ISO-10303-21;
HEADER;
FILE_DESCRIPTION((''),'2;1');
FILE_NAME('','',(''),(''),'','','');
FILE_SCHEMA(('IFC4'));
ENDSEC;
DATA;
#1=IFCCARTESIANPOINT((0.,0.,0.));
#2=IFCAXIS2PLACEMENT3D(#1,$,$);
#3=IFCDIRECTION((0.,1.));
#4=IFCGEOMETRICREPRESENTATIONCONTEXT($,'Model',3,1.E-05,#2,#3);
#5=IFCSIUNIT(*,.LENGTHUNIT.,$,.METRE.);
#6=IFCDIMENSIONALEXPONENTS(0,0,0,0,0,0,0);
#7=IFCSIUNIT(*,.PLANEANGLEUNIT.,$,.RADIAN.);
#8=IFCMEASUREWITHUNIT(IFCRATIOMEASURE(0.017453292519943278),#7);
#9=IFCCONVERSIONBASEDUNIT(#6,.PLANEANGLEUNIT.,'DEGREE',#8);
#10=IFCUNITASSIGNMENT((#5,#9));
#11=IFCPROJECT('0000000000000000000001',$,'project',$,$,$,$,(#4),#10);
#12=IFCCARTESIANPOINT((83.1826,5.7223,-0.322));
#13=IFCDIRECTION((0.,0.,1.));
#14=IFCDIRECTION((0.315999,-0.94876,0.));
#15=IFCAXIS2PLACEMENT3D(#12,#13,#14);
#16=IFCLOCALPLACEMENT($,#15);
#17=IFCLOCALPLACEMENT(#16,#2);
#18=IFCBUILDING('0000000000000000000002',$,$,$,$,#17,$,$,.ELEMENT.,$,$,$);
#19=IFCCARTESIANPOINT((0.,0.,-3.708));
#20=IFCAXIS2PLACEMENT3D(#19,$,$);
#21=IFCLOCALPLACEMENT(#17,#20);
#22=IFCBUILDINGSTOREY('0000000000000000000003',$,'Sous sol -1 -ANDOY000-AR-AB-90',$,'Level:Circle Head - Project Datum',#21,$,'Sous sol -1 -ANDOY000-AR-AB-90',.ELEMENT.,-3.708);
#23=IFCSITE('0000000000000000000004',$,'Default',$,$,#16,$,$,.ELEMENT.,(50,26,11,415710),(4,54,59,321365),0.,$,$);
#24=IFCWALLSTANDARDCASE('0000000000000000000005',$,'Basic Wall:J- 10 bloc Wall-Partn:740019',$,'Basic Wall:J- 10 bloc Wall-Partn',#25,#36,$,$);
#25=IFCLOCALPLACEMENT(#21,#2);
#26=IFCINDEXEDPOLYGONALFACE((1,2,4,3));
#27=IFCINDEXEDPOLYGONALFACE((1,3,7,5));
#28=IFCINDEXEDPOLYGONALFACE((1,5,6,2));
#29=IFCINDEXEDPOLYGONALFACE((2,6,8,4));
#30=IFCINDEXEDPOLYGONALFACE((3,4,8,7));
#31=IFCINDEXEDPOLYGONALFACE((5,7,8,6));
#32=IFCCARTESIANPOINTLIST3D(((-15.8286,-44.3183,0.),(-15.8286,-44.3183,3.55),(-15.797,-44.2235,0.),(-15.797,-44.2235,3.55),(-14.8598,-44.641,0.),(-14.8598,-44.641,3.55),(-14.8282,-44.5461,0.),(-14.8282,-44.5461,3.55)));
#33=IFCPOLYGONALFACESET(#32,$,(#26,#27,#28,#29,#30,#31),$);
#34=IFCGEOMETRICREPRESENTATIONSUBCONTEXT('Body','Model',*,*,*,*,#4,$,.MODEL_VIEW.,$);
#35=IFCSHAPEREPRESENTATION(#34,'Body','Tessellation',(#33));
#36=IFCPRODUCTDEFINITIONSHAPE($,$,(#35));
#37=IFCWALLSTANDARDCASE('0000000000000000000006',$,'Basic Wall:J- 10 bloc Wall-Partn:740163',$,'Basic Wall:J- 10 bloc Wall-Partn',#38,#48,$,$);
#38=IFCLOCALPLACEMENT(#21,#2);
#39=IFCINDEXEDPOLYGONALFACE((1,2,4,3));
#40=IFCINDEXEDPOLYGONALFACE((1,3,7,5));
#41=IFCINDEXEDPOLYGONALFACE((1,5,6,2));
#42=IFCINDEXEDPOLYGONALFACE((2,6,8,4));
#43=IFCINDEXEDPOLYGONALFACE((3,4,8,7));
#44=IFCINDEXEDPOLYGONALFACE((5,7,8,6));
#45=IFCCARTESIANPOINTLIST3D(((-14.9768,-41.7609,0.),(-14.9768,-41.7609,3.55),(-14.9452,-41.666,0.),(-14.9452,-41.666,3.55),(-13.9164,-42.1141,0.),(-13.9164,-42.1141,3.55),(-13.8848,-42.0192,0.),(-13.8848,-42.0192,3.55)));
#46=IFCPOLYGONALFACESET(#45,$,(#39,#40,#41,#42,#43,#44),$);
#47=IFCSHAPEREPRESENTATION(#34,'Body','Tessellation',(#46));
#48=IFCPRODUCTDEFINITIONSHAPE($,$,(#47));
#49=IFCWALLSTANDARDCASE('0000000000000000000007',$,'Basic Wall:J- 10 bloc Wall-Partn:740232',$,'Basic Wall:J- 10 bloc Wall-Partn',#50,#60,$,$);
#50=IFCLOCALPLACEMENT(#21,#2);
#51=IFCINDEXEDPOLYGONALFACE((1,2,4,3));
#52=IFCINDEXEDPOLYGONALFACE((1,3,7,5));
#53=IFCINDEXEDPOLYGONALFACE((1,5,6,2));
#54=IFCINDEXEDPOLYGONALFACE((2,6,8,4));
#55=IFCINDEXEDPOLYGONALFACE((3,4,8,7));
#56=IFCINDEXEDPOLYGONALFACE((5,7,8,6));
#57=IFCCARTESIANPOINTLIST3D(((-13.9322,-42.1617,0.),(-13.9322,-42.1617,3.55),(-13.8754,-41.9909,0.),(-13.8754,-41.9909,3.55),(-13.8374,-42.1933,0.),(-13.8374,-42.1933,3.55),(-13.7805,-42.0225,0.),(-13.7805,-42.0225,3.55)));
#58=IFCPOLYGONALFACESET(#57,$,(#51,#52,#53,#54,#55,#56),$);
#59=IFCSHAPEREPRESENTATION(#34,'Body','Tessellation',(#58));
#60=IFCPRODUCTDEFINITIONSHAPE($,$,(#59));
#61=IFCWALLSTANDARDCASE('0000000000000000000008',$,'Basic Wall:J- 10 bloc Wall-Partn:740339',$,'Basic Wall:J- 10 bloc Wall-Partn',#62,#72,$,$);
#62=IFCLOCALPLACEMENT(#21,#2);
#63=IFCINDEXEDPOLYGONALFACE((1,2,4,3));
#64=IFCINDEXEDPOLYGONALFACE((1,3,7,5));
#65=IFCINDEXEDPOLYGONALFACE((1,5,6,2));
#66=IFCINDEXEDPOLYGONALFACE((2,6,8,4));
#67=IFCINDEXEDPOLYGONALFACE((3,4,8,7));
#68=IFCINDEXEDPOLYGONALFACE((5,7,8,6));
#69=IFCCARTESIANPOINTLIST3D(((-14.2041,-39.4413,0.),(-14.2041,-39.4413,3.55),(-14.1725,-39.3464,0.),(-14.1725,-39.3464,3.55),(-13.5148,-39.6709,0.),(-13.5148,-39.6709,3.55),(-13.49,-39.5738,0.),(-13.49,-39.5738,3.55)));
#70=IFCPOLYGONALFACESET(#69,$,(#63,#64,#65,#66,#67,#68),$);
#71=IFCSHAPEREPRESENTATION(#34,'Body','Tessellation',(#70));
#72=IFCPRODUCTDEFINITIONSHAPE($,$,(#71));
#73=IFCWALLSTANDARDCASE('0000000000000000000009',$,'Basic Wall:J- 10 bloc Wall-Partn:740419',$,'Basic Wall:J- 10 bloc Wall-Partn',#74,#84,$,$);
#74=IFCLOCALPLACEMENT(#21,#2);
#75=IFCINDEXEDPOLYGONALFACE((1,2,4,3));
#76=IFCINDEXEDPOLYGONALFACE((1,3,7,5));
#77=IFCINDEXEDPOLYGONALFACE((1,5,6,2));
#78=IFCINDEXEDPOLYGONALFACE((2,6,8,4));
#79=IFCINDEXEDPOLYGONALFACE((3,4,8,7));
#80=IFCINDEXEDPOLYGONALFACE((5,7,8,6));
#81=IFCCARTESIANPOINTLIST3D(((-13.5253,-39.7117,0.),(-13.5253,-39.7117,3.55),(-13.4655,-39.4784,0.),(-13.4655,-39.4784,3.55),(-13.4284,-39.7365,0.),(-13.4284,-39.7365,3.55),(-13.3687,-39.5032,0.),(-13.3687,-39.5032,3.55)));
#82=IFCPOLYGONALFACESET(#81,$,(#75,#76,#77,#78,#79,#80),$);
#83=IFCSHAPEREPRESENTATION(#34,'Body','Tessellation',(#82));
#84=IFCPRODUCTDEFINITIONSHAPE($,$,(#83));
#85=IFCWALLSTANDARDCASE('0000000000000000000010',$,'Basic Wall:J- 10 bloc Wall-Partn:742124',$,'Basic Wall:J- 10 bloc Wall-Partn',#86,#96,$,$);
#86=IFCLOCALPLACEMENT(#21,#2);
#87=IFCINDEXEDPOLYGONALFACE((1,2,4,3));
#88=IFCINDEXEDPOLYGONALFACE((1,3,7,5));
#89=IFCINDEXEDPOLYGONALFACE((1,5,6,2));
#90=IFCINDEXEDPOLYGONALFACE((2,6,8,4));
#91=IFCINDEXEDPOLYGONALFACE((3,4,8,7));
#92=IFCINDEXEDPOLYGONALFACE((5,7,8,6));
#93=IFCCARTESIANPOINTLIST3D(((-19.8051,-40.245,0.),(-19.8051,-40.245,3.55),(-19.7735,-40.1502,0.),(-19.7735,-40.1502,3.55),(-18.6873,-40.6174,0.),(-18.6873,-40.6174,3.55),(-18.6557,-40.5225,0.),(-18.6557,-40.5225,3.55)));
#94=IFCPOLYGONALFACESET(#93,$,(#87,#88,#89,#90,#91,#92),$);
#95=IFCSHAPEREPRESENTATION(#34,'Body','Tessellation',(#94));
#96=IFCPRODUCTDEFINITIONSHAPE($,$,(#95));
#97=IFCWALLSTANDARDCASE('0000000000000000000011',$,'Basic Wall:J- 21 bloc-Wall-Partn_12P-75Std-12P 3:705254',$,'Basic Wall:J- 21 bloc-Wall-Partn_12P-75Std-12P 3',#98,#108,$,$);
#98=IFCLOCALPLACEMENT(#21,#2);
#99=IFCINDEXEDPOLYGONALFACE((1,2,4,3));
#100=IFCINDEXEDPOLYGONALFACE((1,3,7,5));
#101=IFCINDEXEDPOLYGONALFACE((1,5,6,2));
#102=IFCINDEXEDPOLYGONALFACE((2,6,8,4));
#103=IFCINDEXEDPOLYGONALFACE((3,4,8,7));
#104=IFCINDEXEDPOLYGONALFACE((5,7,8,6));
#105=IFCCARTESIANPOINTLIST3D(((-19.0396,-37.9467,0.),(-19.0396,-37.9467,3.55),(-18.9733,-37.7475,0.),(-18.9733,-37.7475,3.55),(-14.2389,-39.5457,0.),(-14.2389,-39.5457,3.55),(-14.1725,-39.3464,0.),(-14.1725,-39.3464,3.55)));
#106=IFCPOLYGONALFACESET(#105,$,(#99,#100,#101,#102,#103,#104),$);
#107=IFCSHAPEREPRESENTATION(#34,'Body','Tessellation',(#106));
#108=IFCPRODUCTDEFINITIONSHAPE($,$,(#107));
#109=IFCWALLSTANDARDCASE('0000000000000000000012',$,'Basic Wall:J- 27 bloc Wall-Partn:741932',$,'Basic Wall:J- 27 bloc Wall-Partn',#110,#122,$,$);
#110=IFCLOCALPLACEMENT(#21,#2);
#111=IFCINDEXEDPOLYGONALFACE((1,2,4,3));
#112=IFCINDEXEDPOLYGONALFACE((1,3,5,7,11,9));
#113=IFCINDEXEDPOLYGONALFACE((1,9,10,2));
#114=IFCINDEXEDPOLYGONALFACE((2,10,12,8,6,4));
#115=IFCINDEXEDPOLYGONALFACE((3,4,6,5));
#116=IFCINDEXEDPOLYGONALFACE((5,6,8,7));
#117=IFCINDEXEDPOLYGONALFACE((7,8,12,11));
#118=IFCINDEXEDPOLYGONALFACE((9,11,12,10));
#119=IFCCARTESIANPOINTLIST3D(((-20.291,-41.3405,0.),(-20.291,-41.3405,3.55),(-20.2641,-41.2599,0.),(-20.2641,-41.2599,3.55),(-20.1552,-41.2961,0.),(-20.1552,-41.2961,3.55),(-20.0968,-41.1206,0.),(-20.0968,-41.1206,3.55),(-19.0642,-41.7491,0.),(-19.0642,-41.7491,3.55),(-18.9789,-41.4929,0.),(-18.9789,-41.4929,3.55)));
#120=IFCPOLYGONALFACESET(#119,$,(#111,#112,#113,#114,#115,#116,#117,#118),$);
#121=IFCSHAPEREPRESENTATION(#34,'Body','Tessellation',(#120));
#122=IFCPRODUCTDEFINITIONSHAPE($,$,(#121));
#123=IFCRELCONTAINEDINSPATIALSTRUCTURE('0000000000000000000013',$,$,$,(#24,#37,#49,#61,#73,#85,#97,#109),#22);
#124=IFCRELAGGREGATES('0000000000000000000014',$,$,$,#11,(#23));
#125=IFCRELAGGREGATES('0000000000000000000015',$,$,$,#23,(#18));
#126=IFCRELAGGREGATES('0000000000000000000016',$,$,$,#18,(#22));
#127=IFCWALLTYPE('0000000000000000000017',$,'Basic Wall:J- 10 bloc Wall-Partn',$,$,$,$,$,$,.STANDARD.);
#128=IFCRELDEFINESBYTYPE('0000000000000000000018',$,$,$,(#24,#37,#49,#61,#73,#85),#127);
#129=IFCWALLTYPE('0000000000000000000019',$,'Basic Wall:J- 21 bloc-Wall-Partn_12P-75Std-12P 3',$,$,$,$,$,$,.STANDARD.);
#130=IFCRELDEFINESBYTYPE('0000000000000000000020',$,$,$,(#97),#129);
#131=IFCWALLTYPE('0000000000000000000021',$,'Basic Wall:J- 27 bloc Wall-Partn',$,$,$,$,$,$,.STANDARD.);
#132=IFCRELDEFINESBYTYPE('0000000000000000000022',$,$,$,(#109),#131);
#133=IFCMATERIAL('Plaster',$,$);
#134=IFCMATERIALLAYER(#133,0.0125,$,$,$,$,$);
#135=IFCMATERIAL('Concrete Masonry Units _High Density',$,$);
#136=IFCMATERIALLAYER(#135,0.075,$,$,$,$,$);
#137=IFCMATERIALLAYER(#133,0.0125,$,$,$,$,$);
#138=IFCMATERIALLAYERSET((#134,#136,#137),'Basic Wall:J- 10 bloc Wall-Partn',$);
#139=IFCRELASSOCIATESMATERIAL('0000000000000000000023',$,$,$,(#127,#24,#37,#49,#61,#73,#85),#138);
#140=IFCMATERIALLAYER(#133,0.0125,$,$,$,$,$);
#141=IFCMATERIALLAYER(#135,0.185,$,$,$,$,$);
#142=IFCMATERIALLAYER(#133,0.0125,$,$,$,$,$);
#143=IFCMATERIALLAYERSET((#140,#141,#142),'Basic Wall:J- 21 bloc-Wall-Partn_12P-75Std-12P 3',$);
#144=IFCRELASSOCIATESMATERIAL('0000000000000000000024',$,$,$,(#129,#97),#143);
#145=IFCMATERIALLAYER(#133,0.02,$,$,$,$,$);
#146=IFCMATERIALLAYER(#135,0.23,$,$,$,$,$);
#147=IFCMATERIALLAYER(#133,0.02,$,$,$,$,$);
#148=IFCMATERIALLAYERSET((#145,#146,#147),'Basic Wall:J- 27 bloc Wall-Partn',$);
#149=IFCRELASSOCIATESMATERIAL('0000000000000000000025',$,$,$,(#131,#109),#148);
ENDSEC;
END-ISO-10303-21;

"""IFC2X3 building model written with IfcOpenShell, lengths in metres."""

from ifc_helpers import new_model, entity, si_unit, converted_unit, direction, frame, frame_2d, origin, place, context, subcontext, project, spatial, polyline, rectangle, outline, extrude, clip, bounded_halfspace, material, layer, layer_set, layer_usage, type_object, element, save


model = new_model("IFC2X3")

# Units and contexts
model_context = context("Model", 3, precision=1e-05, world=origin(), true_north=direction((0.0, 1.0)))
body_context = subcontext(model_context, "Body", "Model", "MODEL_VIEW")
ifc_project = project(units=[si_unit("LENGTHUNIT", "METRE"), converted_unit("PLANEANGLEUNIT", "DEGREE", entity("IfcRatioMeasure", 0.017453292519943278), si_unit("PLANEANGLEUNIT", "RADIAN"), dimensions=[0, 0, 0, 0, 0, 0, 0])], contexts=[model_context])

# Site, building, storey
site_placement = place(None, frame((83.1826, 5.7223, -0.322), z_axis=(0.0, 0.0, 1.0), x_axis=(0.315999, -0.94876, 0.0)))
site = spatial("IfcSite", under=ifc_project, at=site_placement, Name="Default", CompositionType="ELEMENT", RefLatitude=(50, 26, 11, 415710), RefLongitude=(4, 54, 59, 321365), RefElevation=0.0)
building_placement = place(site_placement, origin())
building = spatial("IfcBuilding", under=site, at=building_placement, CompositionType="ELEMENT")
storey_placement = place(building_placement, frame((0.0, 0.0, -3.708)))
storey = spatial("IfcBuildingStorey", under=building, at=storey_placement, Name="Sous sol -1 -ANDOY000-AR-AB-90", ObjectType="Level:Circle Head - Project Datum", LongName="Sous sol -1 -ANDOY000-AR-AB-90", CompositionType="ELEMENT", Elevation=-3.708)

# Shared definitions
ifc_material_1 = material(Name="Plaster")

# Shared definitions
ifc_layer_1 = layer(ifc_material_1, 0.0125)
ifc_material_2 = material(Name="Concrete Masonry Units _High Density")
ifc_layer_2 = layer(ifc_material_2, 0.075)
ifc_layer_3 = layer(ifc_material_1, 0.0125)
ifc_layer_set_1 = layer_set([ifc_layer_1, ifc_layer_2, ifc_layer_3], Name="Basic Wall:J- 10 bloc Wall-Partn")
ifc_layer_usage_1 = layer_usage(ifc_layer_set_1, "AXIS2", "NEGATIVE", 0.05)
wall_type_1 = type_object("IfcWallType", Name="Basic Wall:J- 10 bloc Wall-Partn", PredefinedType="STANDARD", material=ifc_layer_set_1)

# Walls
wall_1_placement = place(storey_placement, frame((-14.844, -44.5936, 0.0), z_axis=(0.0, 0.0, 1.0), x_axis=(-0.948759, 0.316, 0.0)))
element("IfcWallStandardCase", 1, at=wall_1_placement, inside=storey, type_object=wall_type_1, material=ifc_layer_usage_1, Name="Basic Wall:J- 10 bloc Wall-Partn:740019", ObjectType="Basic Wall:J- 10 bloc Wall-Partn", context=body_context, shape_type="Clipping", body=[
    clip(extrude(rectangle(XDim=1.0211, YDim=0.1, at=frame_2d((0.5105, 0.0), x_axis=(-1.0, 0.0))), origin(), (0.0, 0.0, 1.0), 3.55), bounded_halfspace(frame((0.0, -0.05, 3.55), z_axis=(0.0, 0.0, -1.0), x_axis=(-1.0, 0.0, 0.0)), True, frame((0.0, -0.05, 3.55)), polyline([(0.0, 0.0), (1.0211, 0.0), (1.0211, 0.1), (0.0, 0.1), (0.0, 0.0)]))),
])
wall_2_placement = place(storey_placement, frame((-13.9006, -42.0666, 0.0), z_axis=(0.0, 0.0, 1.0), x_axis=(-0.948763, 0.315987, 0.0)))
element("IfcWallStandardCase", 2, at=wall_2_placement, inside=storey, type_object=wall_type_1, material=ifc_layer_usage_1, Name="Basic Wall:J- 10 bloc Wall-Partn:740163", ObjectType="Basic Wall:J- 10 bloc Wall-Partn", context=body_context, shape_type="Clipping", body=[
    clip(extrude(rectangle(XDim=1.1177, YDim=0.1, at=frame_2d((0.5588, 0.0), x_axis=(-1.0, 0.0))), origin(), (0.0, 0.0, 1.0), 3.55), bounded_halfspace(frame((0.0, -0.05, 3.55), z_axis=(0.0, 0.0, -1.0), x_axis=(-1.0, 0.000014, 0.0)), True, frame((0.0, -0.05, 3.55)), polyline([(0.0, 0.0), (1.1177, 0.0), (1.1177, 0.1), (0.0, 0.1), (0.0, 0.0)]))),
])
wall_3_placement = place(storey_placement, frame((-13.8848, -42.1775, 0.0), z_axis=(0.0, 0.0, 1.0), x_axis=(0.316, 0.948759, 0.0)))
element("IfcWallStandardCase", 3, at=wall_3_placement, inside=storey, type_object=wall_type_1, material=ifc_layer_usage_1, Name="Basic Wall:J- 10 bloc Wall-Partn:740232", ObjectType="Basic Wall:J- 10 bloc Wall-Partn", context=body_context, shape_type="Clipping", body=[
    clip(extrude(rectangle(XDim=0.18, YDim=0.1, at=frame_2d((0.09, 0.0), x_axis=(-1.0, 0.0))), origin(), (0.0, 0.0, 1.0), 3.55), bounded_halfspace(frame((0.0, -0.05, 3.55), z_axis=(0.0, 0.0, -1.0), x_axis=(0.0, -1.0, 0.0)), True, frame((0.0, -0.05, 3.55)), polyline([(0.0, 0.0), (0.18, 0.0), (0.18, 0.1), (0.1502, 0.1), (0.0502, 0.1), (0.0, 0.1), (0.0, 0.0)]))),
])
wall_4_placement = place(storey_placement, frame((-14.1883, -39.3939, 0.0), z_axis=(0.0, 0.0, 1.0), x_axis=(0.948759, -0.316, 0.0)))
element("IfcWallStandardCase", 4, at=wall_4_placement, inside=storey, type_object=wall_type_1, material=ifc_layer_usage_1, Name="Basic Wall:J- 10 bloc Wall-Partn:740339", ObjectType="Basic Wall:J- 10 bloc Wall-Partn", context=body_context, shape_type="Clipping", body=[
    clip(extrude(outline(polyline([(0.7266, -0.05), (0.7195, 0.05), (0.0, 0.05), (0.0, -0.05), (0.7266, -0.05)])), origin(), (0.0, 0.0, 1.0), 3.55), bounded_halfspace(frame((0.0, -0.05, 3.55), z_axis=(0.0, 0.0, -1.0), x_axis=(1.0, 0.0, 0.0)), True, frame((0.0, -0.05, 3.55)), polyline([(0.0, 0.0), (0.7266, 0.0), (0.7195, 0.1), (0.0, 0.1), (0.0, 0.0)]))),
])
wall_5_placement = place(storey_placement, frame((-13.4171, -39.4908, 0.0), z_axis=(0.0, 0.0, 1.0), x_axis=(-0.248019, -0.968755, 0.0)))
element("IfcWallStandardCase", 5, at=wall_5_placement, inside=storey, type_object=wall_type_1, material=ifc_layer_usage_1, Name="Basic Wall:J- 10 bloc Wall-Partn:740419", ObjectType="Basic Wall:J- 10 bloc Wall-Partn", context=body_context, shape_type="Clipping", body=[
    clip(extrude(rectangle(XDim=0.2408, YDim=0.1, at=frame_2d((0.1204, 0.0), x_axis=(-1.0, 0.0))), origin(), (0.0, 0.0, 1.0), 3.55), bounded_halfspace(frame((0.0, -0.05, 3.55), z_axis=(0.0, 0.0, -1.0), x_axis=(0.070817, 0.997489, 0.0)), True, frame((0.0, -0.05, 3.55)), polyline([(0.0, 0.0), (0.0985, 0.0), (0.1987, 0.0), (0.2408, 0.0), (0.2408, 0.1), (0.0, 0.1), (0.0, 0.0)]))),
])
wall_6_placement = place(storey_placement, frame((-18.6715, -40.5699, 0.0), z_axis=(0.0, 0.0, 1.0), x_axis=(-0.948755, 0.316014, 0.0)))
element("IfcWallStandardCase", 6, at=wall_6_placement, inside=storey, type_object=wall_type_1, material=ifc_layer_usage_1, Name="Basic Wall:J- 10 bloc Wall-Partn:742124", ObjectType="Basic Wall:J- 10 bloc Wall-Partn", context=body_context, shape_type="Clipping", body=[
    clip(extrude(rectangle(XDim=1.1782, YDim=0.1, at=frame_2d((0.5891, 0.0), x_axis=(-1.0, 0.0))), origin(), (0.0, 0.0, 1.0), 3.55), bounded_halfspace(frame((0.0, -0.05, 3.55), z_axis=(0.0, 0.0, -1.0), x_axis=(-1.0, -0.000014, 0.0)), True, frame((0.0, -0.05, 3.55)), polyline([(0.0, 0.0), (1.1782, 0.0), (1.1782, 0.1), (0.0, 0.1), (0.0, 0.0)]))),
])
ifc_layer_4 = layer(ifc_material_1, 0.0125)
ifc_layer_5 = layer(ifc_material_2, 0.185)
ifc_layer_6 = layer(ifc_material_1, 0.0125)
ifc_layer_set_2 = layer_set([ifc_layer_4, ifc_layer_5, ifc_layer_6], Name="Basic Wall:J- 21 bloc-Wall-Partn_12P-75Std-12P 3")
ifc_layer_usage_2 = layer_usage(ifc_layer_set_2, "AXIS2", "NEGATIVE", 0.105)
wall_type_2 = type_object("IfcWallType", Name="Basic Wall:J- 21 bloc-Wall-Partn_12P-75Std-12P 3", PredefinedType="STANDARD", material=ifc_layer_set_2)
wall_7_placement = place(storey_placement, frame((-14.2057, -39.446, 0.0), z_axis=(0.0, 0.0, 1.0), x_axis=(-0.948759, 0.316, 0.0)))
element("IfcWallStandardCase", 7, at=wall_7_placement, inside=storey, type_object=wall_type_2, material=ifc_layer_usage_2, Name="Basic Wall:J- 21 bloc-Wall-Partn_12P-75Std-12P 3:705254", ObjectType="Basic Wall:J- 21 bloc-Wall-Partn_12P-75Std-12P 3", context=body_context, shape_type="Clipping", body=[
    clip(extrude(rectangle(XDim=5.06, YDim=0.21, at=frame_2d((2.53, 0.0), x_axis=(-1.0, 0.0))), origin(), (0.0, 0.0, 1.0), 3.55), bounded_halfspace(frame((0.0, -0.105, 3.55), z_axis=(0.0, 0.0, -1.0), x_axis=(-1.0, 0.0, 0.0)), True, frame((0.0, -0.105, 3.55)), polyline([(0.0, 0.0), (0.2099, 0.0), (5.06, 0.0), (5.06, 0.21), (0.21, 0.21), (0.0, 0.21), (0.0, 0.1), (0.0, 0.0)]))),
])
ifc_layer_7 = layer(ifc_material_1, 0.02)
ifc_layer_8 = layer(ifc_material_2, 0.23)
ifc_layer_9 = layer(ifc_material_1, 0.02)
ifc_layer_set_3 = layer_set([ifc_layer_7, ifc_layer_8, ifc_layer_9], Name="Basic Wall:J- 27 bloc Wall-Partn")
ifc_layer_usage_3 = layer_usage(ifc_layer_set_3, "AXIS2", "NEGATIVE", 0.135)
wall_type_3 = type_object("IfcWallType", Name="Basic Wall:J- 27 bloc Wall-Partn", PredefinedType="STANDARD", material=ifc_layer_set_3)
wall_8_placement = place(storey_placement, frame((-19.0216, -41.621, 0.0), z_axis=(0.0, 0.0, 1.0), x_axis=(-0.948759, 0.316, 0.0)))
element("IfcWallStandardCase", 8, at=wall_8_placement, inside=storey, type_object=wall_type_3, material=ifc_layer_usage_3, Name="Basic Wall:J- 27 bloc Wall-Partn:741932", ObjectType="Basic Wall:J- 27 bloc Wall-Partn", context=body_context, shape_type="Clipping", body=[
    clip(extrude(outline(polyline([(1.1782, -0.135), (1.1782, 0.05), (1.293, 0.05), (1.293, 0.135), (0.0, 0.135), (0.0, -0.135), (1.1782, -0.135)])), origin(), (0.0, 0.0, 1.0), 3.55), bounded_halfspace(frame((0.0, -0.135, 3.55), z_axis=(0.0, 0.0, -1.0), x_axis=(-1.0, 0.0, 0.0)), True, frame((0.0, -0.135, 3.55)), polyline([(0.0, 0.0), (1.1782, 0.0), (1.1782, 0.185), (1.293, 0.185), (1.293, 0.27), (0.0, 0.27), (0.0, 0.0)]))),
])

save(model, "model.ifc")
